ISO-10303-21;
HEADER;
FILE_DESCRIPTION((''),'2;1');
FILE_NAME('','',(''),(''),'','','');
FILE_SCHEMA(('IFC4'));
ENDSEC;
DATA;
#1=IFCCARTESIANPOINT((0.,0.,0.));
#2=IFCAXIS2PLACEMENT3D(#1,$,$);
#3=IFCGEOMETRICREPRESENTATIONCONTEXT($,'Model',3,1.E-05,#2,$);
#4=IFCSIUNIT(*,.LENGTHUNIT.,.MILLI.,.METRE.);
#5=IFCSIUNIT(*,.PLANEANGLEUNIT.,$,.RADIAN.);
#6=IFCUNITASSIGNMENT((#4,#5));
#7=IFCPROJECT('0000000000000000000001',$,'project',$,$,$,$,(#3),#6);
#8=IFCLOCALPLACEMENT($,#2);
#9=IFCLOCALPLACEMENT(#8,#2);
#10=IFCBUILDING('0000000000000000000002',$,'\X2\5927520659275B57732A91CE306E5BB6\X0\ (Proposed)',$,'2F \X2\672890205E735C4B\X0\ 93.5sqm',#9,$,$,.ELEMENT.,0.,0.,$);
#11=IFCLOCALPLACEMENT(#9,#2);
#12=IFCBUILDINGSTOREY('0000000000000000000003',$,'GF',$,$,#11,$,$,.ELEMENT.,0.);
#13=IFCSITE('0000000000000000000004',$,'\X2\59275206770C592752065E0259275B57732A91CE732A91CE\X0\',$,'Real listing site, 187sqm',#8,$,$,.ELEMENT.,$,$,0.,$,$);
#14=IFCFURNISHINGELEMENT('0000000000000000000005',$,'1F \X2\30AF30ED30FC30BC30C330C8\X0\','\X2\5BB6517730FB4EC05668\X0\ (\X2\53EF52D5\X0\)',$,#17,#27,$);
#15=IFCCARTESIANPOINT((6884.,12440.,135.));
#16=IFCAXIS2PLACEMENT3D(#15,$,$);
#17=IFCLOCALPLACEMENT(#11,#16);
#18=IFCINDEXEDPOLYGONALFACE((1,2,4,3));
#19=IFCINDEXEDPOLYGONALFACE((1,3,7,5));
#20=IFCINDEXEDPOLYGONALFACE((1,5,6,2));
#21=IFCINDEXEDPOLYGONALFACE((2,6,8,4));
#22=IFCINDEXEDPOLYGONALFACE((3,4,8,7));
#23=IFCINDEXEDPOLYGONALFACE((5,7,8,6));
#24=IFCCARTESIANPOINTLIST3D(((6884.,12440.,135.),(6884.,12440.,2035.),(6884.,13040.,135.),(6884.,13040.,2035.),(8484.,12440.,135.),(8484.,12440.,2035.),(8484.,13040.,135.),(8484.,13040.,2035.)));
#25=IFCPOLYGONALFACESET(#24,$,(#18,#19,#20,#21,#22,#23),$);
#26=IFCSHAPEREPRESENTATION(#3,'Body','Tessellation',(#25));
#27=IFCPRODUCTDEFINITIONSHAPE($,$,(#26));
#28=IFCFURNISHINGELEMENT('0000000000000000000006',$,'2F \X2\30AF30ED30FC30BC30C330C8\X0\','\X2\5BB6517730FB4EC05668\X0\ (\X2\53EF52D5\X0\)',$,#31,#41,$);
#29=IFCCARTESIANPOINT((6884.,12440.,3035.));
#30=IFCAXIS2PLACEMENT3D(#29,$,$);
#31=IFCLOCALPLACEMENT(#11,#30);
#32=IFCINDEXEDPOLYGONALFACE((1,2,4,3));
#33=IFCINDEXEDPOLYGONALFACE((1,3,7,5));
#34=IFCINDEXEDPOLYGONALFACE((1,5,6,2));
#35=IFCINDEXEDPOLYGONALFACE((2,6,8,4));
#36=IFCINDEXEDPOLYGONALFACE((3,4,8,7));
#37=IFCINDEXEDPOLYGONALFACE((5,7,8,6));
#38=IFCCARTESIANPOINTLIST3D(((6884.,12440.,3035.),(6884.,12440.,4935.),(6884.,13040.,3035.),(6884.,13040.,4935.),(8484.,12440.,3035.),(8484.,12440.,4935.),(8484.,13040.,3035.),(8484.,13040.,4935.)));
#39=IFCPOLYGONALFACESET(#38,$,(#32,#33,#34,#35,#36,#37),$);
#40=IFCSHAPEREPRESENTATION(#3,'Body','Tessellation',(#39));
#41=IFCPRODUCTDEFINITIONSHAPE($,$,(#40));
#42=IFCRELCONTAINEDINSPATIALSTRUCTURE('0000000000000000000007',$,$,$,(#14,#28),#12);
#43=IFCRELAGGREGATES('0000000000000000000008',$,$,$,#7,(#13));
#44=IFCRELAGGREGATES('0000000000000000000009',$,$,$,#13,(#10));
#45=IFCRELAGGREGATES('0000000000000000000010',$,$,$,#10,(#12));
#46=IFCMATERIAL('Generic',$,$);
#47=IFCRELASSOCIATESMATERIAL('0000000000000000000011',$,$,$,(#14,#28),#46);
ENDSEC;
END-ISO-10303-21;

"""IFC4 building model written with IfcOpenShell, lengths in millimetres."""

from ifc_helpers import new_model, si_unit, frame, frame_2d, origin, place, context, project, spatial, rectangle, extrude, material, element, save


model = new_model("IFC4")

# Units and contexts
model_context = context("Model", 3, precision=1e-05, world=origin())
ifc_project = project(units=[si_unit("LENGTHUNIT", "METRE", prefix="MILLI"), si_unit("PLANEANGLEUNIT", "RADIAN")], contexts=[model_context])

# Site, building, storey
site_placement = place(None, origin())
site = spatial("IfcSite", under=ifc_project, at=site_placement, Name="大分県大分市大字猪野猪野", ObjectType="Real listing site, 187sqm", CompositionType="ELEMENT", RefElevation=0.0)
building_placement = place(site_placement, origin())
building = spatial("IfcBuilding", under=site, at=building_placement, Name="大分大字猪野の家 (Proposed)", ObjectType="2F 木造平屋 93.5sqm", CompositionType="ELEMENT", ElevationOfRefHeight=0.0, ElevationOfTerrain=0.0)
storey_placement = place(building_placement, origin())
storey = spatial("IfcBuildingStorey", under=building, at=storey_placement, Name="GF", CompositionType="ELEMENT", Elevation=0.0)

# Shared definitions
ifc_material_1 = material(Name="Generic")

# Furnishing elements
furnishing_1_placement = place(storey_placement, frame((6884.0, 12440.0, 135.0)))
element("IfcFurnishingElement", 1, at=furnishing_1_placement, inside=storey, material=ifc_material_1, Name="1F クローゼット", Description="家具・什器 (可動)", context=model_context, shape_type="SweptSolid", body=[
    extrude(rectangle(XDim=1600.0, YDim=600.0, at=frame_2d((800.0, 300.0))), frame((6884.0, 12440.0, 135.0)), (0.0, 0.0, 1.0), 1900.0),
])
furnishing_2_placement = place(storey_placement, frame((6884.0, 12440.0, 3035.0)))
element("IfcFurnishingElement", 2, at=furnishing_2_placement, inside=storey, material=ifc_material_1, Name="2F クローゼット", Description="家具・什器 (可動)", context=model_context, shape_type="SweptSolid", body=[
    extrude(rectangle(XDim=1600.0, YDim=600.0, at=frame_2d((800.0, 300.0))), frame((6884.0, 12440.0, 3035.0)), (0.0, 0.0, 1.0), 1900.0),
])

save(model, "model.ifc")
